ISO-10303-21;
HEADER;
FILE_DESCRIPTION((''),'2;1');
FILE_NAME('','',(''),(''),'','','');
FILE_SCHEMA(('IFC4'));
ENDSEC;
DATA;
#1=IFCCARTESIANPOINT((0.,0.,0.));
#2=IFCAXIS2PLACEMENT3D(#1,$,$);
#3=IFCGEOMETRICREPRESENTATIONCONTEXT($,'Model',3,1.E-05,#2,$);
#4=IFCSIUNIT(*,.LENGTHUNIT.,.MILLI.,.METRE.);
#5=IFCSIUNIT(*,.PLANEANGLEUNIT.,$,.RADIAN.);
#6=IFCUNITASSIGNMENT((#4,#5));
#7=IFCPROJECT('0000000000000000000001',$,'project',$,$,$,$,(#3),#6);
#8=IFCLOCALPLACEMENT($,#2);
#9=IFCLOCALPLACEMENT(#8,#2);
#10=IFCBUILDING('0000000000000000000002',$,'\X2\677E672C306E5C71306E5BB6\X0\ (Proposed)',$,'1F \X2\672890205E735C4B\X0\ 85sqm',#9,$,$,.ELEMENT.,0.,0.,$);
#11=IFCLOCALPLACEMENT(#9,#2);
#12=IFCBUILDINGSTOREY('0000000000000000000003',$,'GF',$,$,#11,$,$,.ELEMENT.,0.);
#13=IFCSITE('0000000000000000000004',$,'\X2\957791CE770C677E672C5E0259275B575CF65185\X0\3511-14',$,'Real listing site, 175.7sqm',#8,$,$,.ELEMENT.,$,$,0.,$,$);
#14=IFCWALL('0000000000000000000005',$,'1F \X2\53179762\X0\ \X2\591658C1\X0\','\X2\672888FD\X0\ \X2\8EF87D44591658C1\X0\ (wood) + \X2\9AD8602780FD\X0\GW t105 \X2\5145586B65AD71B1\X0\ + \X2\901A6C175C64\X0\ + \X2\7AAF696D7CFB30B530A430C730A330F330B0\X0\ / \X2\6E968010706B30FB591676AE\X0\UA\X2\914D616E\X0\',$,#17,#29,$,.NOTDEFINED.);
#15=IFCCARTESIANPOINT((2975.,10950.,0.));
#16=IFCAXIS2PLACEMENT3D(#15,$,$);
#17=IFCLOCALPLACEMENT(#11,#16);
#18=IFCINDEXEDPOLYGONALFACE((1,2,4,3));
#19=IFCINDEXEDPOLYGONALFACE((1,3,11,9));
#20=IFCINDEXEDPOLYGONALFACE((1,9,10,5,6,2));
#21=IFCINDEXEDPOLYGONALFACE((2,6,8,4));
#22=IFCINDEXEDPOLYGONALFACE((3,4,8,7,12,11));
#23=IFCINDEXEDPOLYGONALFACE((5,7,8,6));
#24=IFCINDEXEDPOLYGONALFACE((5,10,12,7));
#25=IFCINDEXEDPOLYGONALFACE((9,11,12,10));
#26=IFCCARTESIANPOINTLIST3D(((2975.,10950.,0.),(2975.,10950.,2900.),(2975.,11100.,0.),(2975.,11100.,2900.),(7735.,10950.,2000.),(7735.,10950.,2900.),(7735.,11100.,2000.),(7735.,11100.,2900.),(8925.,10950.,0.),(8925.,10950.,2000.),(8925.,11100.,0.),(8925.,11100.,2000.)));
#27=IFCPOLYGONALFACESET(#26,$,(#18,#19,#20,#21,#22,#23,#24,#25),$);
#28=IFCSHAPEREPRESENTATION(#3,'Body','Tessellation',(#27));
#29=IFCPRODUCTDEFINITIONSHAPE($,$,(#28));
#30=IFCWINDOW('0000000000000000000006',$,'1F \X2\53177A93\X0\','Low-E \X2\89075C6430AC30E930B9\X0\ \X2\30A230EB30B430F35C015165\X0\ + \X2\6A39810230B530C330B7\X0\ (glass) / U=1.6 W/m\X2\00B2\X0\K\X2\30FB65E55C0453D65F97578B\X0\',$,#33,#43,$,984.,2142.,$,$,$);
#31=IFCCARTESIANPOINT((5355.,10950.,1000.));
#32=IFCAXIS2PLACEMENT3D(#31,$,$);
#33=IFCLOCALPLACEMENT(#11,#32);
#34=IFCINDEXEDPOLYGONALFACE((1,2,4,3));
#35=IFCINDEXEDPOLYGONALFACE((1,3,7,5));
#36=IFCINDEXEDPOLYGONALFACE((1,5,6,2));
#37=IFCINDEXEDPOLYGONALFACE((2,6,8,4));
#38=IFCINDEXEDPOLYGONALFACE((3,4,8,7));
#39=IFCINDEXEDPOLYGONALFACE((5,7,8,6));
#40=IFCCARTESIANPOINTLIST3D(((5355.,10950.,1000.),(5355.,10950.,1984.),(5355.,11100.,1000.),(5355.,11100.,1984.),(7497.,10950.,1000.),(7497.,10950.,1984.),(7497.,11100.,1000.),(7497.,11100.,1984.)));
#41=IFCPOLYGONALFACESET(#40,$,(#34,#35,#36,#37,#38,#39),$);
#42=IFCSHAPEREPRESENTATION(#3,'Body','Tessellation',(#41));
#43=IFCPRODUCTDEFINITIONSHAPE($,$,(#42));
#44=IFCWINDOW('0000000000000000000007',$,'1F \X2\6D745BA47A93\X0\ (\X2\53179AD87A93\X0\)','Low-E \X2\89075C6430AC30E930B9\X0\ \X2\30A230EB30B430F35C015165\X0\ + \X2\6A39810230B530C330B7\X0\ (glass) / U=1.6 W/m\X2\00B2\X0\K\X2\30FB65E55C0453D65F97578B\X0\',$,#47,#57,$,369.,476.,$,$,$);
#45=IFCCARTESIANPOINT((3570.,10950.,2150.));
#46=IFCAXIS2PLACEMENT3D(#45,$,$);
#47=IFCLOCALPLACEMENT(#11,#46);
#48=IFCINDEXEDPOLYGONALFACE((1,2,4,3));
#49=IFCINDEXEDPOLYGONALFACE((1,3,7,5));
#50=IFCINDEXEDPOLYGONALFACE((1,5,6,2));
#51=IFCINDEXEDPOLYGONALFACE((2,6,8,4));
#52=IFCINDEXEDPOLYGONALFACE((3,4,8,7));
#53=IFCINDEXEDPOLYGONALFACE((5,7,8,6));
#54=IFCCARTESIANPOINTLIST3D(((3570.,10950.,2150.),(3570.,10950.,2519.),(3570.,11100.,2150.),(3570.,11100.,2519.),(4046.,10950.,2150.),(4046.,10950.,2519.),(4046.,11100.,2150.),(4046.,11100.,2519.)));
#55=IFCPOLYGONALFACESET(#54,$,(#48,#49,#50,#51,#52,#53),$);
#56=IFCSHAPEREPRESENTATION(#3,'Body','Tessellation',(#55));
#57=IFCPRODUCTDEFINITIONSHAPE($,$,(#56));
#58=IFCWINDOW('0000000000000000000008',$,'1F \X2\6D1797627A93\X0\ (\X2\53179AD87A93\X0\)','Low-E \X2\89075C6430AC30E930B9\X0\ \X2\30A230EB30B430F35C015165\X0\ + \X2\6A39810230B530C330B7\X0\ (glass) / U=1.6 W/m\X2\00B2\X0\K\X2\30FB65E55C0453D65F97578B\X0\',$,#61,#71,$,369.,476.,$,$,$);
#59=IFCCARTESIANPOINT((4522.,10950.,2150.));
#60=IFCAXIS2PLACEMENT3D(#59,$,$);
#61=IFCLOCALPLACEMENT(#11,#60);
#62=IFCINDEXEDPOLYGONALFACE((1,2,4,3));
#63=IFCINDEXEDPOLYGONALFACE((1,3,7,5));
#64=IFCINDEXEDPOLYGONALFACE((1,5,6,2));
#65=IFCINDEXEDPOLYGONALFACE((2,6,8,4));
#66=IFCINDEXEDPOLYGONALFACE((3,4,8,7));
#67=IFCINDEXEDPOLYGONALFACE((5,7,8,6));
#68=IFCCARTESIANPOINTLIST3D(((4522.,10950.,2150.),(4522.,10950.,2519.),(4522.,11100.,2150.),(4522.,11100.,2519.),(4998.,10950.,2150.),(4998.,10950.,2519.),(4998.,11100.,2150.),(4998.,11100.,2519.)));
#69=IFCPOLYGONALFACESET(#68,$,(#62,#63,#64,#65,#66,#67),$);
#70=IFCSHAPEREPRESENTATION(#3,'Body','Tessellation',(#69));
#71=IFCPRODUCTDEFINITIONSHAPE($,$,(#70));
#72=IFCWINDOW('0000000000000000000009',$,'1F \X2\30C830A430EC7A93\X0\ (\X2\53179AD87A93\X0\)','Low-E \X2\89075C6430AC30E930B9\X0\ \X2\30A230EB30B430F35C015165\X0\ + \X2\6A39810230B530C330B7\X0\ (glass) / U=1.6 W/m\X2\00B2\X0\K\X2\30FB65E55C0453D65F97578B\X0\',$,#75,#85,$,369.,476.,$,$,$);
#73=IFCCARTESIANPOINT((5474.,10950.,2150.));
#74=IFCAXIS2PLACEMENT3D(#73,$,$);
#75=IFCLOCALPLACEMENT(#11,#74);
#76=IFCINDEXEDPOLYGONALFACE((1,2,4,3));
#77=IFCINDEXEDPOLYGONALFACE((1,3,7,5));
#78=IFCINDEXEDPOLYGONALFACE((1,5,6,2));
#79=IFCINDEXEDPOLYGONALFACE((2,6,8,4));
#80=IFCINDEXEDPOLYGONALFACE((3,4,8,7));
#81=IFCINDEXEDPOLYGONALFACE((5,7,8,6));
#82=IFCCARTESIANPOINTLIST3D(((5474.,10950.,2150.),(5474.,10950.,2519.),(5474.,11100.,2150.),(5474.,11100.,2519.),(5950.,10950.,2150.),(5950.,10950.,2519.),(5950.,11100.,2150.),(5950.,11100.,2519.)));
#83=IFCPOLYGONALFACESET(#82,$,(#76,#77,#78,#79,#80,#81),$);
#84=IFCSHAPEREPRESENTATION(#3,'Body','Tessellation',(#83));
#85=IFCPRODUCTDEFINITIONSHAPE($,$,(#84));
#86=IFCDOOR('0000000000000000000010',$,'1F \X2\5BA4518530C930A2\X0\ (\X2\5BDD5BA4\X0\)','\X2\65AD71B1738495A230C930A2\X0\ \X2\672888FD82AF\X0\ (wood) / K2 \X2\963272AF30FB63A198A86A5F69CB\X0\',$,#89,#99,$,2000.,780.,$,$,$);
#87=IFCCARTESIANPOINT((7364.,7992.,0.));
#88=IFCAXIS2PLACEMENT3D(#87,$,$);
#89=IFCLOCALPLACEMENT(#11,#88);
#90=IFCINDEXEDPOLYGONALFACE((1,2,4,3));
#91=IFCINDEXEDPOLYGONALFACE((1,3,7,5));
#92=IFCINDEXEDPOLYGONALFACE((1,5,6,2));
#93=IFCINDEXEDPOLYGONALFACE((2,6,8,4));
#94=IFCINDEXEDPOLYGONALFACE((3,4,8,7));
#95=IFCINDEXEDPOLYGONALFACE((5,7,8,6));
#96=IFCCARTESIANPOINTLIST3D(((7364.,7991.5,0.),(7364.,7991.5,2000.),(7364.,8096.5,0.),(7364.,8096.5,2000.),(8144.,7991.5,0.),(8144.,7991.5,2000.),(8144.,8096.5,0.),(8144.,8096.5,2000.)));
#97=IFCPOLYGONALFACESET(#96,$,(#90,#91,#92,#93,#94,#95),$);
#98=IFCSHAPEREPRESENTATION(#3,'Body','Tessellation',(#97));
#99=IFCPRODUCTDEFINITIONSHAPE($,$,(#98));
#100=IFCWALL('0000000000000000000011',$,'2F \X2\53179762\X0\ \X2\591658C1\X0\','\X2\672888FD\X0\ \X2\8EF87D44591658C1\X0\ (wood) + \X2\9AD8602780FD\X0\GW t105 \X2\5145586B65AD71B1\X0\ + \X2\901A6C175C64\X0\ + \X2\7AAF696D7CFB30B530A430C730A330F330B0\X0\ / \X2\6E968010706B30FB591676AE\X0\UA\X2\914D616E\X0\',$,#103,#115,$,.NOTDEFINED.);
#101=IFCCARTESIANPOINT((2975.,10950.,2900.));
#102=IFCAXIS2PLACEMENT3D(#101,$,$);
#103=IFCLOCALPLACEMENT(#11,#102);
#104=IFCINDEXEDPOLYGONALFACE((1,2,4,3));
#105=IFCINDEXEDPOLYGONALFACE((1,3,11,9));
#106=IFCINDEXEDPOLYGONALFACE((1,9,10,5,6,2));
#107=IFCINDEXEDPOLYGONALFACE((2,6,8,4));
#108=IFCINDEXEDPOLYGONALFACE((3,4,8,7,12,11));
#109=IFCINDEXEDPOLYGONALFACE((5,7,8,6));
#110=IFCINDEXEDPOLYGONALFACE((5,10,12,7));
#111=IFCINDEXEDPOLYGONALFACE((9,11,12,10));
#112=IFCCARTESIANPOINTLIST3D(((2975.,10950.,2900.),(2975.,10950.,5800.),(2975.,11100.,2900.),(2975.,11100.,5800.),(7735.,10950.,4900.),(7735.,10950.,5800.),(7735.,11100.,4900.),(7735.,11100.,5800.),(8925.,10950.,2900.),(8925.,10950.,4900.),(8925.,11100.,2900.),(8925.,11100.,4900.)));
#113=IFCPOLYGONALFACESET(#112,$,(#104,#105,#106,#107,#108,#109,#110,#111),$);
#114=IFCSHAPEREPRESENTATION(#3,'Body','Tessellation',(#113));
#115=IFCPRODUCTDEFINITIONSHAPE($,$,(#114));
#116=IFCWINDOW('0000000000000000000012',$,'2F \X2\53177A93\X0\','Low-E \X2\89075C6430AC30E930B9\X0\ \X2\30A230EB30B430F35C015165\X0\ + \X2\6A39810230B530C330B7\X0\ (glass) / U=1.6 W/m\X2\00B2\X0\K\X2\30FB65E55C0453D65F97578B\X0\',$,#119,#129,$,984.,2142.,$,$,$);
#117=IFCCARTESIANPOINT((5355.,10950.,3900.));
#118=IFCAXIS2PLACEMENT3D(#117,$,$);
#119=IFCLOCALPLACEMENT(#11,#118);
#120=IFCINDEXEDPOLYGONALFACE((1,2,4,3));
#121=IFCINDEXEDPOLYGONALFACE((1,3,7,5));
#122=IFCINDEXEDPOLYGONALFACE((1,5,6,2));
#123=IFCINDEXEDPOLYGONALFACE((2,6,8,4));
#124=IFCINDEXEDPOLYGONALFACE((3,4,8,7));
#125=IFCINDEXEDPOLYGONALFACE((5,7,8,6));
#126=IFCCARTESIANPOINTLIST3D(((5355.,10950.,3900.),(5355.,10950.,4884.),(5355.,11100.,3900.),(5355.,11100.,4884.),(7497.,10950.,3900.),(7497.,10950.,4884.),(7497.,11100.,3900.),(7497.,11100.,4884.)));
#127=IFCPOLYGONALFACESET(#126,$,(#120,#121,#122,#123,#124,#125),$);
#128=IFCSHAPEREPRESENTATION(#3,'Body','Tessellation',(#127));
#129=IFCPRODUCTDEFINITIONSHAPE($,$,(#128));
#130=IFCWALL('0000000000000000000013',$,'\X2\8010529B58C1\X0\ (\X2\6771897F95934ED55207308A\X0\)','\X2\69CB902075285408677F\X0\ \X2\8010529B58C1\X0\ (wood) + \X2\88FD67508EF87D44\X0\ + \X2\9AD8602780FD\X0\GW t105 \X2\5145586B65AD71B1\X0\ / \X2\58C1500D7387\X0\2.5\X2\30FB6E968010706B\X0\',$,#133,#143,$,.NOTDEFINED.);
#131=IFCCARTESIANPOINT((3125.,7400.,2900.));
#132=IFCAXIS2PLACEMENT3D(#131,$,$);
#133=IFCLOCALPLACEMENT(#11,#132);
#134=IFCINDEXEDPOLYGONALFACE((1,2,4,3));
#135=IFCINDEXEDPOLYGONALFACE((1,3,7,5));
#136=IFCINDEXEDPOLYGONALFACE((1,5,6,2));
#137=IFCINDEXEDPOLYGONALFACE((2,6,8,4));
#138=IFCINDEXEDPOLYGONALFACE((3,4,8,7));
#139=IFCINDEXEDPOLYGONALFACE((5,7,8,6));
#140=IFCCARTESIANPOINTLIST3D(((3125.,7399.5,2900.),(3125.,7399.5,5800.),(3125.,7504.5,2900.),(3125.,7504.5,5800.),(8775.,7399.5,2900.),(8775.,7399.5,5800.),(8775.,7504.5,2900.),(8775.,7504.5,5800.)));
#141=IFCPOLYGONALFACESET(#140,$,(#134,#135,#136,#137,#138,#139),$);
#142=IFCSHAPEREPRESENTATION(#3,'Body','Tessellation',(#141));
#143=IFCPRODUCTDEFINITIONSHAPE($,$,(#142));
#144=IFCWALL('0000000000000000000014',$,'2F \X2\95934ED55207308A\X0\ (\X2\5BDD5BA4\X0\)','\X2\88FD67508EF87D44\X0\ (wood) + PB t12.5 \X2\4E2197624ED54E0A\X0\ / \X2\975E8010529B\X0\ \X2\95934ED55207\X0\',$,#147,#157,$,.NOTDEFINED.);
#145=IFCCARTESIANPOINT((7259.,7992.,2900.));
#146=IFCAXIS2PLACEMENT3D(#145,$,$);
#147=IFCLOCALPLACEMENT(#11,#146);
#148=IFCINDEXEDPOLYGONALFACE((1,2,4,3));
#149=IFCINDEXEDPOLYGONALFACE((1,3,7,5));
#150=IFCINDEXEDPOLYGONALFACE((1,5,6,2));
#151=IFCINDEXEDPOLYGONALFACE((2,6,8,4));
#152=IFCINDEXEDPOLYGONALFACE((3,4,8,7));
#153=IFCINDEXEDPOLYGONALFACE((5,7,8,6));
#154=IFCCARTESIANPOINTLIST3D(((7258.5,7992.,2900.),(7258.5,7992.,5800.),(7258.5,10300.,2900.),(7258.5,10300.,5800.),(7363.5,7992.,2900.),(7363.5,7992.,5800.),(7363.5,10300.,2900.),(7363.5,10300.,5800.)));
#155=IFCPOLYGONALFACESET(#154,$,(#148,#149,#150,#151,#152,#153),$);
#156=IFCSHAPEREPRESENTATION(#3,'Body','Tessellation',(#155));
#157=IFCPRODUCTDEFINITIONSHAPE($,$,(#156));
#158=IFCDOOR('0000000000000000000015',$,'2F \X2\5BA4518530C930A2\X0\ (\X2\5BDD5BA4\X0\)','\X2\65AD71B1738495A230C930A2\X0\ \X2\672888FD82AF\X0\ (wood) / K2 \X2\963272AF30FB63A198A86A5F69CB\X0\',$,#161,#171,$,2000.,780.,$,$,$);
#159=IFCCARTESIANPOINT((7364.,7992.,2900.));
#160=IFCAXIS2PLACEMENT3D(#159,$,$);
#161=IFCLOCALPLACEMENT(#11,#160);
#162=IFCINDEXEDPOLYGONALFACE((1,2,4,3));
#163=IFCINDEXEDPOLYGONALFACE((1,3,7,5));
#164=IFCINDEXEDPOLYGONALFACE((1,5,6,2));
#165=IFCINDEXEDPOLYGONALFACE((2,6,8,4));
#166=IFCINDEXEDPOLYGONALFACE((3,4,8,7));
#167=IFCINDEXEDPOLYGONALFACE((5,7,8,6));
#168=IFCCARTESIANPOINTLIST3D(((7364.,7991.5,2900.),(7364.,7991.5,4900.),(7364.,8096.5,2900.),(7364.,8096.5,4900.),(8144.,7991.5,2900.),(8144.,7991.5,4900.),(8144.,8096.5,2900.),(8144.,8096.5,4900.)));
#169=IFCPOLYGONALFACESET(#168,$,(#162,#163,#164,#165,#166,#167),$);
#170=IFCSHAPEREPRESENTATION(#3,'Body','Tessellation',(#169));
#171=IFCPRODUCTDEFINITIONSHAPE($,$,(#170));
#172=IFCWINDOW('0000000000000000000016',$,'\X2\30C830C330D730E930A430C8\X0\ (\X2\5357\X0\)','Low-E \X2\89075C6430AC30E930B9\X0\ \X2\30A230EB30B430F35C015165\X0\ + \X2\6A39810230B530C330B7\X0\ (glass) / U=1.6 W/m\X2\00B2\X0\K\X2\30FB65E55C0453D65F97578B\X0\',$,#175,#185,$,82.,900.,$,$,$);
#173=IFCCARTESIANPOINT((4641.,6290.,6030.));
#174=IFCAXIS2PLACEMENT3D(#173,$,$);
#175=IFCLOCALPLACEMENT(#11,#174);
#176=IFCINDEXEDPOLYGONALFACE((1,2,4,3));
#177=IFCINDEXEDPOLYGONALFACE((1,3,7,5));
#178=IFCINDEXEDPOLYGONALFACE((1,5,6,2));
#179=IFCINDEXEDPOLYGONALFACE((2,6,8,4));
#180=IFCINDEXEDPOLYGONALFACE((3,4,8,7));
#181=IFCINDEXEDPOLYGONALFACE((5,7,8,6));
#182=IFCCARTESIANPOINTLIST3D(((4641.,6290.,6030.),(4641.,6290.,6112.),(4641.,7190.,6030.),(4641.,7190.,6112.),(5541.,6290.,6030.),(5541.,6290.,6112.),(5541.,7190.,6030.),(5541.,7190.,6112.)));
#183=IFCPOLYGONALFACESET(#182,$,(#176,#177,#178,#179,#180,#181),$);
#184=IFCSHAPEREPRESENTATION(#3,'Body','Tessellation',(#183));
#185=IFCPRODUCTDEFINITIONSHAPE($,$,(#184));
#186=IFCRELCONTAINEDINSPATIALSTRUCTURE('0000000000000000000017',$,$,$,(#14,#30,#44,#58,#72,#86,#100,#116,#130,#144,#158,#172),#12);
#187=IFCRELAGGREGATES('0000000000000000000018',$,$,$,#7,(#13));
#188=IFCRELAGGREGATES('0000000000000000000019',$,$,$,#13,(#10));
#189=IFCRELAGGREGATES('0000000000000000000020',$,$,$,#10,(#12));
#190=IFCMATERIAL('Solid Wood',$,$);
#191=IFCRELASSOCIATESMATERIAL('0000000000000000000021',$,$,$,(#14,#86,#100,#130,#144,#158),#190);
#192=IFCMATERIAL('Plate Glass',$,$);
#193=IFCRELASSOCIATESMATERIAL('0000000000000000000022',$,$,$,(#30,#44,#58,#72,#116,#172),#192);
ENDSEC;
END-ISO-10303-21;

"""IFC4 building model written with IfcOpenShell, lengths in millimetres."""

from ifc_helpers import new_model, si_unit, frame, frame_2d, origin, place, context, project, spatial, rectangle, extrude, material, element, fill, save


model = new_model("IFC4")

# Units and contexts
model_context = context("Model", 3, precision=1e-05, world=origin())
ifc_project = project(units=[si_unit("LENGTHUNIT", "METRE", prefix="MILLI"), si_unit("PLANEANGLEUNIT", "RADIAN")], contexts=[model_context])

# Site, building, storey
site_placement = place(None, origin())
site = spatial("IfcSite", under=ifc_project, at=site_placement, Name="長野県松本市大字島内3511-14", ObjectType="Real listing site, 175.7sqm", CompositionType="ELEMENT", RefElevation=0.0)
building_placement = place(site_placement, origin())
building = spatial("IfcBuilding", under=site, at=building_placement, Name="松本の山の家 (Proposed)", ObjectType="1F 木造平屋 85sqm", CompositionType="ELEMENT", ElevationOfRefHeight=0.0, ElevationOfTerrain=0.0)
storey_placement = place(building_placement, origin())
storey = spatial("IfcBuildingStorey", under=building, at=storey_placement, Name="GF", CompositionType="ELEMENT", Elevation=0.0)

# Wall, openings, windows
ifc_material_1 = material(Name="Solid Wood")
wall_1_placement = place(storey_placement, frame((2975.0, 10950.0, 0.0)))
wall_1 = element("IfcWall", 1, at=wall_1_placement, inside=storey, material=ifc_material_1, Name="1F 北面 外壁", Description="木製 軸組外壁 (wood) + 高性能GW t105 充填断熱 + 通気層 + 窯業系サイディング / 準耐火・外皮UA配慮", PredefinedType="NOTDEFINED", context=model_context, shape_type="SweptSolid", body=[
    extrude(rectangle(XDim=5950.0, YDim=150.0, at=frame_2d((2975.0, 75.0))), frame((2975.0, 10950.0, 0.0)), (0.0, 0.0, 1.0), 2900.0),
])
opening_1_placement = place(storey_placement, frame((5355.0, 10950.0, 1000.0)))
opening_1 = element("IfcOpeningElement", 2, at=opening_1_placement, cuts=wall_1, PredefinedType="NOTDEFINED", context=model_context, shape_type="SweptSolid", body=[
    extrude(rectangle(XDim=2142.0, YDim=150.0, at=frame_2d((1071.0, 75.0))), frame((5355.0, 10950.0, 1000.0)), (0.0, 0.0, 1.0), 984.0),
])
opening_2_placement = place(storey_placement, frame((3570.0, 10950.0, 2150.0)))
opening_2 = element("IfcOpeningElement", 3, at=opening_2_placement, cuts=wall_1, PredefinedType="NOTDEFINED", context=model_context, shape_type="SweptSolid", body=[
    extrude(rectangle(XDim=476.0, YDim=150.0, at=frame_2d((238.0, 75.0))), frame((3570.0, 10950.0, 2150.0)), (0.0, 0.0, 1.0), 369.0),
])
opening_3_placement = place(storey_placement, frame((4522.0, 10950.0, 2150.0)))
opening_3 = element("IfcOpeningElement", 4, at=opening_3_placement, cuts=wall_1, PredefinedType="NOTDEFINED", context=model_context, shape_type="SweptSolid", body=[
    extrude(rectangle(XDim=476.0, YDim=150.0, at=frame_2d((238.0, 75.0))), frame((4522.0, 10950.0, 2150.0)), (0.0, 0.0, 1.0), 369.0),
])
opening_4_placement = place(storey_placement, frame((5474.0, 10950.0, 2150.0)))
opening_4 = element("IfcOpeningElement", 5, at=opening_4_placement, cuts=wall_1, PredefinedType="NOTDEFINED", context=model_context, shape_type="SweptSolid", body=[
    extrude(rectangle(XDim=476.0, YDim=150.0, at=frame_2d((238.0, 75.0))), frame((5474.0, 10950.0, 2150.0)), (0.0, 0.0, 1.0), 369.0),
])
ifc_material_2 = material(Name="Plate Glass")
window_1_placement = place(storey_placement, frame((5355.0, 10950.0, 1000.0)))
window_1 = element("IfcWindow", 6, at=window_1_placement, inside=storey, material=ifc_material_2, Name="1F 北窓", Description="Low-E 複層ガラス アルゴン封入 + 樹脂サッシ (glass) / U=1.6 W/m²K・日射取得型", OverallHeight=984.0, OverallWidth=2142.0, context=model_context, shape_type="SweptSolid", body=[
    extrude(rectangle(XDim=2142.0, YDim=150.0, at=frame_2d((1071.0, 75.0))), frame((5355.0, 10950.0, 1000.0)), (0.0, 0.0, 1.0), 984.0),
])
fill(opening_1, window_1)
window_2_placement = place(storey_placement, frame((3570.0, 10950.0, 2150.0)))
window_2 = element("IfcWindow", 7, at=window_2_placement, inside=storey, material=ifc_material_2, Name="1F 浴室窓 (北高窓)", Description="Low-E 複層ガラス アルゴン封入 + 樹脂サッシ (glass) / U=1.6 W/m²K・日射取得型", OverallHeight=369.0, OverallWidth=476.0, context=model_context, shape_type="SweptSolid", body=[
    extrude(rectangle(XDim=476.0, YDim=150.0, at=frame_2d((238.0, 75.0))), frame((3570.0, 10950.0, 2150.0)), (0.0, 0.0, 1.0), 369.0),
])
fill(opening_2, window_2)
window_3_placement = place(storey_placement, frame((4522.0, 10950.0, 2150.0)))
window_3 = element("IfcWindow", 8, at=window_3_placement, inside=storey, material=ifc_material_2, Name="1F 洗面窓 (北高窓)", Description="Low-E 複層ガラス アルゴン封入 + 樹脂サッシ (glass) / U=1.6 W/m²K・日射取得型", OverallHeight=369.0, OverallWidth=476.0, context=model_context, shape_type="SweptSolid", body=[
    extrude(rectangle(XDim=476.0, YDim=150.0, at=frame_2d((238.0, 75.0))), frame((4522.0, 10950.0, 2150.0)), (0.0, 0.0, 1.0), 369.0),
])
fill(opening_3, window_3)
window_4_placement = place(storey_placement, frame((5474.0, 10950.0, 2150.0)))
window_4 = element("IfcWindow", 9, at=window_4_placement, inside=storey, material=ifc_material_2, Name="1F トイレ窓 (北高窓)", Description="Low-E 複層ガラス アルゴン封入 + 樹脂サッシ (glass) / U=1.6 W/m²K・日射取得型", OverallHeight=369.0, OverallWidth=476.0, context=model_context, shape_type="SweptSolid", body=[
    extrude(rectangle(XDim=476.0, YDim=150.0, at=frame_2d((238.0, 75.0))), frame((5474.0, 10950.0, 2150.0)), (0.0, 0.0, 1.0), 369.0),
])
fill(opening_4, window_4)

# Door
door_1_placement = place(storey_placement, frame((7364.0, 7992.0, 0.0)))
element("IfcDoor", 10, at=door_1_placement, inside=storey, material=ifc_material_1, Name="1F 室内ドア (寝室)", Description="断熱玄関ドア 木製芯 (wood) / K2 防犯・採風機構", OverallHeight=2000.0, OverallWidth=780.0, context=model_context, shape_type="SweptSolid", body=[
    extrude(rectangle(XDim=780.0, YDim=105.0, at=frame_2d((390.0, 52.0))), frame((7364.0, 7992.0, 0.0)), (0.0, 0.0, 1.0), 2000.0),
])

# Wall, opening, window
wall_2_placement = place(storey_placement, frame((2975.0, 10950.0, 2900.0)))
wall_2 = element("IfcWall", 11, at=wall_2_placement, inside=storey, material=ifc_material_1, Name="2F 北面 外壁", Description="木製 軸組外壁 (wood) + 高性能GW t105 充填断熱 + 通気層 + 窯業系サイディング / 準耐火・外皮UA配慮", PredefinedType="NOTDEFINED", context=model_context, shape_type="SweptSolid", body=[
    extrude(rectangle(XDim=5950.0, YDim=150.0, at=frame_2d((2975.0, 75.0))), frame((2975.0, 10950.0, 2900.0)), (0.0, 0.0, 1.0), 2900.0),
])
opening_5_placement = place(storey_placement, frame((5355.0, 10950.0, 3900.0)))
opening_5 = element("IfcOpeningElement", 12, at=opening_5_placement, cuts=wall_2, PredefinedType="NOTDEFINED", context=model_context, shape_type="SweptSolid", body=[
    extrude(rectangle(XDim=2142.0, YDim=150.0, at=frame_2d((1071.0, 75.0))), frame((5355.0, 10950.0, 3900.0)), (0.0, 0.0, 1.0), 984.0),
])
window_5_placement = place(storey_placement, frame((5355.0, 10950.0, 3900.0)))
window_5 = element("IfcWindow", 13, at=window_5_placement, inside=storey, material=ifc_material_2, Name="2F 北窓", Description="Low-E 複層ガラス アルゴン封入 + 樹脂サッシ (glass) / U=1.6 W/m²K・日射取得型", OverallHeight=984.0, OverallWidth=2142.0, context=model_context, shape_type="SweptSolid", body=[
    extrude(rectangle(XDim=2142.0, YDim=150.0, at=frame_2d((1071.0, 75.0))), frame((5355.0, 10950.0, 3900.0)), (0.0, 0.0, 1.0), 984.0),
])
fill(opening_5, window_5)

# Walls
wall_3_placement = place(storey_placement, frame((3125.0, 7400.0, 2900.0)))
element("IfcWall", 14, at=wall_3_placement, inside=storey, material=ifc_material_1, Name="耐力壁 (東西間仕切り)", Description="構造用合板 耐力壁 (wood) + 製材軸組 + 高性能GW t105 充填断熱 / 壁倍率2.5・準耐火", PredefinedType="NOTDEFINED", context=model_context, shape_type="SweptSolid", body=[
    extrude(rectangle(XDim=5650.0, YDim=105.0, at=frame_2d((2825.0, 52.0))), frame((3125.0, 7400.0, 2900.0)), (0.0, 0.0, 1.0), 2900.0),
])
wall_4_placement = place(storey_placement, frame((7259.0, 7992.0, 2900.0)))
element("IfcWall", 15, at=wall_4_placement, inside=storey, material=ifc_material_1, Name="2F 間仕切り (寝室)", Description="製材軸組 (wood) + PB t12.5 両面仕上 / 非耐力 間仕切", PredefinedType="NOTDEFINED", context=model_context, shape_type="SweptSolid", body=[
    extrude(rectangle(XDim=105.0, YDim=2308.0, at=frame_2d((52.0, 1154.0))), frame((7259.0, 7992.0, 2900.0)), (0.0, 0.0, 1.0), 2900.0),
])

# Door
door_2_placement = place(storey_placement, frame((7364.0, 7992.0, 2900.0)))
element("IfcDoor", 16, at=door_2_placement, inside=storey, material=ifc_material_1, Name="2F 室内ドア (寝室)", Description="断熱玄関ドア 木製芯 (wood) / K2 防犯・採風機構", OverallHeight=2000.0, OverallWidth=780.0, context=model_context, shape_type="SweptSolid", body=[
    extrude(rectangle(XDim=780.0, YDim=105.0, at=frame_2d((390.0, 52.0))), frame((7364.0, 7992.0, 2900.0)), (0.0, 0.0, 1.0), 2000.0),
])

# Window
window_6_placement = place(storey_placement, frame((4641.0, 6290.0, 6030.0)))
element("IfcWindow", 17, at=window_6_placement, inside=storey, material=ifc_material_2, Name="トップライト (南)", Description="Low-E 複層ガラス アルゴン封入 + 樹脂サッシ (glass) / U=1.6 W/m²K・日射取得型", OverallHeight=82.0, OverallWidth=900.0, context=model_context, shape_type="SweptSolid", body=[
    extrude(rectangle(XDim=900.0, YDim=900.0, at=frame_2d((450.0, 450.0))), frame((4641.0, 6290.0, 6030.0)), (0.0, 0.0, 1.0), 82.0),
])

save(model, "model.ifc")
